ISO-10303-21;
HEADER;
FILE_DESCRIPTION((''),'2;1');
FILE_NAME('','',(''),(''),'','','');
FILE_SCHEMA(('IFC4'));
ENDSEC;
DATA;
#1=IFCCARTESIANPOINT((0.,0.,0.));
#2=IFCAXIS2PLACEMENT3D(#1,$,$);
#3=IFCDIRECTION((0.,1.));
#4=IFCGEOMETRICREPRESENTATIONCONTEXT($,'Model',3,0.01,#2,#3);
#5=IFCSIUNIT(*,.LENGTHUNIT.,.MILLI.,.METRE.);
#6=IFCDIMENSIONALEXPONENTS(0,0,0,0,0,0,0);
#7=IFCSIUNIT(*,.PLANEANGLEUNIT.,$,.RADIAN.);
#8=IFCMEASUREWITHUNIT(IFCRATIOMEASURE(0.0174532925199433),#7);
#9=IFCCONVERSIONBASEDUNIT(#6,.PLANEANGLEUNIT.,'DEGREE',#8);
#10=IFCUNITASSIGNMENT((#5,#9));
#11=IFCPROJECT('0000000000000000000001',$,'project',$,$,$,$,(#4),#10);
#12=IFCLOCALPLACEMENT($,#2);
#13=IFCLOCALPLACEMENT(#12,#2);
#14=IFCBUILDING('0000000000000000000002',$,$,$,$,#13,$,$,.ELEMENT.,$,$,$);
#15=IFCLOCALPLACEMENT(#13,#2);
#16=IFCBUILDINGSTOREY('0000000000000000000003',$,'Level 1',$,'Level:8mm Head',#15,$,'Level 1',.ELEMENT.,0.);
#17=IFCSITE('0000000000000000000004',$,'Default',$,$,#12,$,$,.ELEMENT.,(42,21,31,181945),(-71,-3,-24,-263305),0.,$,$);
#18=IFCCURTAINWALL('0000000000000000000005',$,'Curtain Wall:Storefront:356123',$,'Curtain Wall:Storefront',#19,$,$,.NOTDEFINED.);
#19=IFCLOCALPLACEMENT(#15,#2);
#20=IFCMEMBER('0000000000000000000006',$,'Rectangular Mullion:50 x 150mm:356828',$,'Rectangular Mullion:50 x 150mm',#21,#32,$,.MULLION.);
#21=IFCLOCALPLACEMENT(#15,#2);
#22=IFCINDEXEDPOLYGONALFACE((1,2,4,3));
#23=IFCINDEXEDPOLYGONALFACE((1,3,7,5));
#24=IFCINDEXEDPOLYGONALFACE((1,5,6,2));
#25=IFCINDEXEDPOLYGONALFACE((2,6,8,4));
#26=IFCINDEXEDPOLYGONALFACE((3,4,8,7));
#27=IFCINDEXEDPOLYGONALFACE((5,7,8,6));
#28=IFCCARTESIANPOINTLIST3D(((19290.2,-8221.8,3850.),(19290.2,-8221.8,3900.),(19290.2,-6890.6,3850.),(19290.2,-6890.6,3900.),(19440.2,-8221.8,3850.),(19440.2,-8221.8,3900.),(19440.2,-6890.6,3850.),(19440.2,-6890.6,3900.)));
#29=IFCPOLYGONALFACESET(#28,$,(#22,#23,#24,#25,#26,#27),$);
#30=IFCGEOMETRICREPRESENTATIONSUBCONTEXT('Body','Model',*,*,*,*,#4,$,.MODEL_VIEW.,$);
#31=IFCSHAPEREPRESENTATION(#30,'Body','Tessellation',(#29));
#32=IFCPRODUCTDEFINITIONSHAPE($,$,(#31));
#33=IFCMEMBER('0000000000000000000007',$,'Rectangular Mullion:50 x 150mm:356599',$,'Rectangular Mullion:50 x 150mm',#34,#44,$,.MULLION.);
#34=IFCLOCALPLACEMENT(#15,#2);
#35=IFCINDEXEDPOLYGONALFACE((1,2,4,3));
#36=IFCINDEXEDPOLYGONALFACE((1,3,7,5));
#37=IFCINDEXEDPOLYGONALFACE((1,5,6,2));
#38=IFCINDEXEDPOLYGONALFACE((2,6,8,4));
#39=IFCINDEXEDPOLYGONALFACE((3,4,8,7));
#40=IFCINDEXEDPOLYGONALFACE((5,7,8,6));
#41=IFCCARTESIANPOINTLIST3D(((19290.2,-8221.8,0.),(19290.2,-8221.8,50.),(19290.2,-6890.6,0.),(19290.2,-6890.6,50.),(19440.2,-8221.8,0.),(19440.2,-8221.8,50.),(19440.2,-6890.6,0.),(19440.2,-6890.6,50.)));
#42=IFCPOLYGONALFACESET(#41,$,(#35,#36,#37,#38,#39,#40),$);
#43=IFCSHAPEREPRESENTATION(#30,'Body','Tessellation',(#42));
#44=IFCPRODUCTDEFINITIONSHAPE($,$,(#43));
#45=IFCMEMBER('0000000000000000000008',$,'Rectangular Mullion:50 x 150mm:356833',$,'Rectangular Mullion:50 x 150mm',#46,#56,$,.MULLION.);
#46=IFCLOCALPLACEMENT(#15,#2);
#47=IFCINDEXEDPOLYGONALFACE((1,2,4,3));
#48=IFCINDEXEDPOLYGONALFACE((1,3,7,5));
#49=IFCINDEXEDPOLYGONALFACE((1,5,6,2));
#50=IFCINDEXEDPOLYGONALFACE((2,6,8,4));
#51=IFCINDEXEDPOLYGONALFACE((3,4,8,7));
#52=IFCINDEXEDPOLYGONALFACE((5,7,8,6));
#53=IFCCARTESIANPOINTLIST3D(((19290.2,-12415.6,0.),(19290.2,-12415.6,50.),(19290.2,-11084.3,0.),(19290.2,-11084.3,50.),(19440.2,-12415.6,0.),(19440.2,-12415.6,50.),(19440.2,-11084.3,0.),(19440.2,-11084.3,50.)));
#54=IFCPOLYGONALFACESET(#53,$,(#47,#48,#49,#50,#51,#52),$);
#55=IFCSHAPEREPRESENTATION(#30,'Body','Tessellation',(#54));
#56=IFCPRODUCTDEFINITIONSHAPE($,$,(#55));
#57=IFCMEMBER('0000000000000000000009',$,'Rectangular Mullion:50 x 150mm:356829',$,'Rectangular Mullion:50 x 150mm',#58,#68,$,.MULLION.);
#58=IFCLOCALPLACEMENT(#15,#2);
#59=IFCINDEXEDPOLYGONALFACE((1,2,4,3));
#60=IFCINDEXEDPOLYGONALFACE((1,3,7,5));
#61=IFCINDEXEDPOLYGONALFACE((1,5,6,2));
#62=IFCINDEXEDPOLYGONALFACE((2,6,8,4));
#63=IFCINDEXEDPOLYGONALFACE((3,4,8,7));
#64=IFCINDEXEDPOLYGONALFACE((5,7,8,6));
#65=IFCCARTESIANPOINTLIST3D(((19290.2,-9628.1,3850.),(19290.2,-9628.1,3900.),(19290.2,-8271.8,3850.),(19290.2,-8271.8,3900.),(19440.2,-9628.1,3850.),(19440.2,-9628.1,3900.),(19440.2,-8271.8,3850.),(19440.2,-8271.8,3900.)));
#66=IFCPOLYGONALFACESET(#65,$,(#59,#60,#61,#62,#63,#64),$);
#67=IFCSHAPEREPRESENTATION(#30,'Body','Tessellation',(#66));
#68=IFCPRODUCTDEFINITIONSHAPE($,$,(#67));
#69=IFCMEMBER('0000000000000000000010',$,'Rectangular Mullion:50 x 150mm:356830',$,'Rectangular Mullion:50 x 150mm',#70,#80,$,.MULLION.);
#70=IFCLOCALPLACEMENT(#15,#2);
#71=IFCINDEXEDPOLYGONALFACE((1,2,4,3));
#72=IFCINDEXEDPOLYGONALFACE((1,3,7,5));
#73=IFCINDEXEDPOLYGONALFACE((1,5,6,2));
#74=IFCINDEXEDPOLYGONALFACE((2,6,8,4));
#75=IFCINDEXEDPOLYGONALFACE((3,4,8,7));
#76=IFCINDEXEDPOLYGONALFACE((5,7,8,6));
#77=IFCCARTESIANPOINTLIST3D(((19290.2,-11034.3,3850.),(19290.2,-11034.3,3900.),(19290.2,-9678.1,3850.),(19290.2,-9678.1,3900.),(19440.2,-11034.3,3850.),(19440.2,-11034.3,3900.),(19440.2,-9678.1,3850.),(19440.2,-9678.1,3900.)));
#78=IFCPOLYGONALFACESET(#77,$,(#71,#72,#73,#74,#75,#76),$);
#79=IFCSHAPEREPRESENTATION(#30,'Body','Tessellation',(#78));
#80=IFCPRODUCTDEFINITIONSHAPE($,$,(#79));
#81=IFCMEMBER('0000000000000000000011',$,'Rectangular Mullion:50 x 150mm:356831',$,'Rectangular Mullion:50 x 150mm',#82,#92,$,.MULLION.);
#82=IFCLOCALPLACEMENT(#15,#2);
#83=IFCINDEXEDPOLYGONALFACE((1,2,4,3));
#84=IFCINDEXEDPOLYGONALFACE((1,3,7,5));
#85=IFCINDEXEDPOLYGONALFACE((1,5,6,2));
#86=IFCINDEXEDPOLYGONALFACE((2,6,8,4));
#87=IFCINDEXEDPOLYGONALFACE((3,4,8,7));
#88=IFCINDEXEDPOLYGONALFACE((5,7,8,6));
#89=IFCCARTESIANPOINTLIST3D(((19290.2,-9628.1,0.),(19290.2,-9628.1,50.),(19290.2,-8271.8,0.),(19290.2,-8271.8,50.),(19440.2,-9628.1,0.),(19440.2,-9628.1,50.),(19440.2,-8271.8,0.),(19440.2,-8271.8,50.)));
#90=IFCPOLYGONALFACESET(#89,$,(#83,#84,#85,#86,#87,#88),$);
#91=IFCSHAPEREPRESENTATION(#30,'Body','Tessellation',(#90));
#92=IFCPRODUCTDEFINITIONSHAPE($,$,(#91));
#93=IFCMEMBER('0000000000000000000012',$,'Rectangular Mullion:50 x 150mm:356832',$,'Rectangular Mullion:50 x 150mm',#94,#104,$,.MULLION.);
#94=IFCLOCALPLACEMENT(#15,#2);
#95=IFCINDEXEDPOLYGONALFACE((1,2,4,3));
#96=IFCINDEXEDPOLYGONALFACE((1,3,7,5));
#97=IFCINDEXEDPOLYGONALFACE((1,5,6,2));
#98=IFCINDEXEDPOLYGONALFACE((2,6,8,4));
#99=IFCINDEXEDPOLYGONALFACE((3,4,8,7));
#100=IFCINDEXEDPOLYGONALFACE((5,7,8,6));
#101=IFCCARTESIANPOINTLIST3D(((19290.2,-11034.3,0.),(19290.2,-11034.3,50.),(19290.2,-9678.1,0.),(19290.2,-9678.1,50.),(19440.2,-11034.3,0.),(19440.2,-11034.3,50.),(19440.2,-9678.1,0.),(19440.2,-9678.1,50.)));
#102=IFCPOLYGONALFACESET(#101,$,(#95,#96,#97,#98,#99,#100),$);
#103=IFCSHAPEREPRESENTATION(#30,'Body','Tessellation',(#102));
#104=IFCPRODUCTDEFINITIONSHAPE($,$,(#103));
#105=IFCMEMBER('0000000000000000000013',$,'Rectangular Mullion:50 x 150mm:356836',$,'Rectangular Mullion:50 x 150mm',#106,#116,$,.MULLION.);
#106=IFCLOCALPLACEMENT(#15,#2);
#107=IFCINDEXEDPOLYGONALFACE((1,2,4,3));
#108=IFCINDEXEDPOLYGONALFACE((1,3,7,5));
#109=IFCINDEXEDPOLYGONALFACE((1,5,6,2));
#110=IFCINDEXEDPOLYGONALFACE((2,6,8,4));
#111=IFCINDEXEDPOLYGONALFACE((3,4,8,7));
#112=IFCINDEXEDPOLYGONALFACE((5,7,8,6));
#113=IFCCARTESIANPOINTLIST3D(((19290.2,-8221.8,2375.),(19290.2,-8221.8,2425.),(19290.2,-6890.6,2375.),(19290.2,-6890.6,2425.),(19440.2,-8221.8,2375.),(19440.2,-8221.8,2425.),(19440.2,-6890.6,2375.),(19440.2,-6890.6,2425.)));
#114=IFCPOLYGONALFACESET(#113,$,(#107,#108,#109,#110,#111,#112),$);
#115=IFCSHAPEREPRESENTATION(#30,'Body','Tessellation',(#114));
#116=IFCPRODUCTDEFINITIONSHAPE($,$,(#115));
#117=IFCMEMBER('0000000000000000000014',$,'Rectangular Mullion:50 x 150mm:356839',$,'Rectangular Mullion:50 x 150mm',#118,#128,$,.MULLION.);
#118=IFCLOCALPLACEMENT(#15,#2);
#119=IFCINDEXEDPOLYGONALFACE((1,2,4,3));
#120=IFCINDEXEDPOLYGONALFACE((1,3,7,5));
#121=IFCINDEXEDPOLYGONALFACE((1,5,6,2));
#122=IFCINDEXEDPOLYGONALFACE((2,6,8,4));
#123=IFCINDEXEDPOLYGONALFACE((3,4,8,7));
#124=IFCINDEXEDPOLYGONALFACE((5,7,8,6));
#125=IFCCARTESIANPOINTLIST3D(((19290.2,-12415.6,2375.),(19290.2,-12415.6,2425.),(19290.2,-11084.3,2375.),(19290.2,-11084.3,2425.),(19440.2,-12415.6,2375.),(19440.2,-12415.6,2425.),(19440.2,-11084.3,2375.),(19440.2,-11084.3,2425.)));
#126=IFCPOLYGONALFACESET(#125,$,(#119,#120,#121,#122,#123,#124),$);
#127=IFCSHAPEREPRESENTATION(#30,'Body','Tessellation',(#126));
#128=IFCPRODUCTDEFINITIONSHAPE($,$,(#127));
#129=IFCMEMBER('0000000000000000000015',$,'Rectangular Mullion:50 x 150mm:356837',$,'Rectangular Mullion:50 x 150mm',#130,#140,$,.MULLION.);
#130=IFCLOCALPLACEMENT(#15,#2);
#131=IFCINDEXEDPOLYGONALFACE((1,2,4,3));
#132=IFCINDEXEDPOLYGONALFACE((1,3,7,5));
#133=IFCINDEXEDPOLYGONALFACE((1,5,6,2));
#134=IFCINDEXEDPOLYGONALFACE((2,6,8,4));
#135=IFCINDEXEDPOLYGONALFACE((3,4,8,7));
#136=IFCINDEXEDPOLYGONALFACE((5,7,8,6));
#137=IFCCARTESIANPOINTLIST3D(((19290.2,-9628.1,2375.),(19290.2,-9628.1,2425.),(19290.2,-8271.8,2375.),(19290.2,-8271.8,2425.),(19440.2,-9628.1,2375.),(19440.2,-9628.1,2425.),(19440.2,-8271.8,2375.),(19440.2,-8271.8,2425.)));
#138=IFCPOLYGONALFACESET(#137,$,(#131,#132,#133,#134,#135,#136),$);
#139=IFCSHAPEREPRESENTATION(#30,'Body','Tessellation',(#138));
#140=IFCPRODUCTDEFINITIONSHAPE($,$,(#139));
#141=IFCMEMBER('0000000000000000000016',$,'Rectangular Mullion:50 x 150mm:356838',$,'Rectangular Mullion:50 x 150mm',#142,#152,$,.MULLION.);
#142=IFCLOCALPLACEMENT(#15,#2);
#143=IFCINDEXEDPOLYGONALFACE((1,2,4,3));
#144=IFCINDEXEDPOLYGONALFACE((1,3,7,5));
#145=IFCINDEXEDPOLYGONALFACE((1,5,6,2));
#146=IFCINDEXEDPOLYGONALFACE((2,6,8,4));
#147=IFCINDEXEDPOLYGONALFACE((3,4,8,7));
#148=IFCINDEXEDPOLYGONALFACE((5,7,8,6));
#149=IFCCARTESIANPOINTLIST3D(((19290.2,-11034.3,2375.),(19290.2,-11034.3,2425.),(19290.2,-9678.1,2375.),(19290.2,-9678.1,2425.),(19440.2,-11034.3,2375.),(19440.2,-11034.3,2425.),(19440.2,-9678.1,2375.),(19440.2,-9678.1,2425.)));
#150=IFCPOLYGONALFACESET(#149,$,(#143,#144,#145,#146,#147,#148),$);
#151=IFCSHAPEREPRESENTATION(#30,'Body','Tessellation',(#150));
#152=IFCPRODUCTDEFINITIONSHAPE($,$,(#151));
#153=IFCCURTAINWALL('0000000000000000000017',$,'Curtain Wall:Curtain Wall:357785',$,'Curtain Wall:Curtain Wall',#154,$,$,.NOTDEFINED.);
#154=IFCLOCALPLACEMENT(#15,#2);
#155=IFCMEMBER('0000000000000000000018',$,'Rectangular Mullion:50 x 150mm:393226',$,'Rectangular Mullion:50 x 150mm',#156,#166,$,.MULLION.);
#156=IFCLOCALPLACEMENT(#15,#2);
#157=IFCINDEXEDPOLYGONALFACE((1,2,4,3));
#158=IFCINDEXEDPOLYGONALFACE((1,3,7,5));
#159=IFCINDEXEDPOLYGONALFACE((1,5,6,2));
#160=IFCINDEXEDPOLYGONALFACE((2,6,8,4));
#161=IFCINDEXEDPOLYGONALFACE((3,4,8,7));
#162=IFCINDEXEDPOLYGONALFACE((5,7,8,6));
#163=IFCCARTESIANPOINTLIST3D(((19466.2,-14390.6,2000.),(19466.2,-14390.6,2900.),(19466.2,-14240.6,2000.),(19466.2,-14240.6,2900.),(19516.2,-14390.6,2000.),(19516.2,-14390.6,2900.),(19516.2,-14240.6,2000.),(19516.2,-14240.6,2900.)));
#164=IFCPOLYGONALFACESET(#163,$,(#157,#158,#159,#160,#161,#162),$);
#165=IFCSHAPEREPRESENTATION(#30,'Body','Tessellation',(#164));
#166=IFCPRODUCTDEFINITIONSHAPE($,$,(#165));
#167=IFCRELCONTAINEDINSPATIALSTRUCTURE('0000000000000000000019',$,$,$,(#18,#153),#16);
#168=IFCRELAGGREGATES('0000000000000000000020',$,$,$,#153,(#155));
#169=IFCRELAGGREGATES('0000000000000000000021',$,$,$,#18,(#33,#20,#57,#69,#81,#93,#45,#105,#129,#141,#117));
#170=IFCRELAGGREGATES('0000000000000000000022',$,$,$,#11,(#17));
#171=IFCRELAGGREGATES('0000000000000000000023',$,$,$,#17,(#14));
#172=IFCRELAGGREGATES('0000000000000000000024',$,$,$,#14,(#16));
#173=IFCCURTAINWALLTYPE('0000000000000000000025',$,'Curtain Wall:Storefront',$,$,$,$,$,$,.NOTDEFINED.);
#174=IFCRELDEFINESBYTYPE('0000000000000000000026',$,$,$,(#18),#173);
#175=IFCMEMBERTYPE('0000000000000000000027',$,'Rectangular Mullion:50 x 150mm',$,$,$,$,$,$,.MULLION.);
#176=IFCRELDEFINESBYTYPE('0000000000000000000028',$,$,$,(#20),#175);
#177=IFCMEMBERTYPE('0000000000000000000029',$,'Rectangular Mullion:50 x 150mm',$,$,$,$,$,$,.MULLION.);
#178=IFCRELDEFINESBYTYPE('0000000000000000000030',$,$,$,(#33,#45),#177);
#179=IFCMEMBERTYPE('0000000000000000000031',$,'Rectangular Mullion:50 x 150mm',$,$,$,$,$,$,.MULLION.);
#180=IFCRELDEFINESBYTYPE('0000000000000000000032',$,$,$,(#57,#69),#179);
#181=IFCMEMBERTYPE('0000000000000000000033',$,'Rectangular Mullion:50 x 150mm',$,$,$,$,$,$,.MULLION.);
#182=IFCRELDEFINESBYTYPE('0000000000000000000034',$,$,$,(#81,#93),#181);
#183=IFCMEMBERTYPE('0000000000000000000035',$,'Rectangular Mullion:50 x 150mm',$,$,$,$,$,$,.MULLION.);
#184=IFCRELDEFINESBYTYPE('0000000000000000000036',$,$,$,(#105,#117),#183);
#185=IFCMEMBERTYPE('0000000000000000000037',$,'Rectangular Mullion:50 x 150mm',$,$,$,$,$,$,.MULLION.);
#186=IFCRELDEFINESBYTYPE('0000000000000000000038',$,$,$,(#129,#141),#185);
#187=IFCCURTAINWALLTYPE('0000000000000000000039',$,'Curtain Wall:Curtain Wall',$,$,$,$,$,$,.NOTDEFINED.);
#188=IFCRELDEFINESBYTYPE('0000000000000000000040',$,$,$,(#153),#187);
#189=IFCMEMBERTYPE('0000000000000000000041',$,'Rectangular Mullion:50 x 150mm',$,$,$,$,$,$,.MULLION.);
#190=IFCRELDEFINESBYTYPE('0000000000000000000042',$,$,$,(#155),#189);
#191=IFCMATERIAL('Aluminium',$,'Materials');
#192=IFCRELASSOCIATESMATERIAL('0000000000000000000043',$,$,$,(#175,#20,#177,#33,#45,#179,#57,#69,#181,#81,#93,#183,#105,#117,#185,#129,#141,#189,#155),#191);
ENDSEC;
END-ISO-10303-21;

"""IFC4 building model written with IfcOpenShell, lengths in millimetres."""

from ifc_helpers import new_model, entity, si_unit, converted_unit, direction, frame, origin, place, context, subcontext, project, spatial, indexed_curve, outline, extrude, source, transform, mapped, material, type_object, type_shapes, element, aggregate, save


model = new_model("IFC4")

# Units and contexts
model_context = context("Model", 3, precision=0.01, world=origin(), true_north=direction((0.0, 1.0)))
body_context = subcontext(model_context, "Body", "Model", "MODEL_VIEW")
ifc_project = project(units=[si_unit("LENGTHUNIT", "METRE", prefix="MILLI"), converted_unit("PLANEANGLEUNIT", "DEGREE", entity("IfcRatioMeasure", 0.0174532925199433), si_unit("PLANEANGLEUNIT", "RADIAN"), dimensions=[0, 0, 0, 0, 0, 0, 0])], contexts=[model_context])

# Site, building, storey
site_placement = place(None, origin())
site = spatial("IfcSite", under=ifc_project, at=site_placement, Name="Default", CompositionType="ELEMENT", RefLatitude=(42, 21, 31, 181945), RefLongitude=(-71, -3, -24, -263305), RefElevation=0.0)
building_placement = place(site_placement, origin())
building = spatial("IfcBuilding", under=site, at=building_placement, CompositionType="ELEMENT")
storey_placement = place(building_placement, origin())
storey = spatial("IfcBuildingStorey", under=building, at=storey_placement, Name="Level 1", ObjectType="Level:8mm Head", LongName="Level 1", CompositionType="ELEMENT", Elevation=0.0)

# Shared definitions
curtain_wall_type_1 = type_object("IfcCurtainWallType", Name="Curtain Wall:Storefront", PredefinedType="NOTDEFINED")
ifc_material_1 = material(Name="Aluminium", Category="Materials")

# Curtain walls, members
curtain_wall_1_placement = place(storey_placement, origin())
curtain_wall_1 = element("IfcCurtainWall", 1, at=curtain_wall_1_placement, inside=storey, type_object=curtain_wall_type_1, Name="Curtain Wall:Storefront:356123", ObjectType="Curtain Wall:Storefront", PredefinedType="NOTDEFINED")
member_type_1 = type_object("IfcMemberType", Name="Rectangular Mullion:50 x 150mm", PredefinedType="MULLION", material=ifc_material_1)
shared_shape_1 = source(origin(), body_context, "Body", "SweptSolid", [
    extrude(outline(indexed_curve([(-75.0, -25.0), (75.0, -25.0), (75.0, 25.0), (-75.0, 25.0), (-75.0, -25.0)], self_intersect=False)), frame((-25.0, 0.0, -1331.3), z_axis=(0.0, 0.0, 1.0), x_axis=(0.0, -1.0, 0.0)), (0.0, 0.0, 1.0), 1331.3),
])
type_shapes(member_type_1, [shared_shape_1])
member_1_placement = place(storey_placement, frame((19365.2, -8221.8, 3900.0), z_axis=(0.0, -1.0, 0.0), x_axis=(0.0, 0.0, 1.0)))
member_1 = element("IfcMember", 2, at=member_1_placement, type_object=member_type_1, material=ifc_material_1, Name="Rectangular Mullion:50 x 150mm:356828", ObjectType="Rectangular Mullion:50 x 150mm", PredefinedType="MULLION", context=body_context, shape_type="MappedRepresentation", body=[
    mapped(shared_shape_1, transform((0.0, 0.0, 0.0), scale=1.0)),
])
member_type_2 = type_object("IfcMemberType", Name="Rectangular Mullion:50 x 150mm", PredefinedType="MULLION", material=ifc_material_1)
shared_shape_2 = source(origin(), body_context, "Body", "SweptSolid", [
    extrude(outline(indexed_curve([(-75.0, -25.0), (75.0, -25.0), (75.0, 25.0), (-75.0, 25.0), (-75.0, -25.0)], self_intersect=False)), frame((-25.0, 0.0, -1331.3), z_axis=(0.0, 0.0, 1.0), x_axis=(0.0, -1.0, 0.0)), (0.0, 0.0, 1.0), 1331.3),
])
type_shapes(member_type_2, [shared_shape_2])
member_2_placement = place(storey_placement, frame((19365.2, -6890.6, 0.0), z_axis=(0.0, 1.0, 0.0), x_axis=(0.0, 0.0, -1.0)))
member_2 = element("IfcMember", 3, at=member_2_placement, type_object=member_type_2, material=ifc_material_1, Name="Rectangular Mullion:50 x 150mm:356599", ObjectType="Rectangular Mullion:50 x 150mm", PredefinedType="MULLION", context=body_context, shape_type="MappedRepresentation", body=[
    mapped(shared_shape_2, transform((0.0, 0.0, 0.0), scale=1.0)),
])
member_3_placement = place(storey_placement, frame((19365.2, -11084.3, 0.0), z_axis=(0.0, 1.0, 0.0), x_axis=(0.0, 0.0, -1.0)))
member_3 = element("IfcMember", 4, at=member_3_placement, type_object=member_type_2, material=ifc_material_1, Name="Rectangular Mullion:50 x 150mm:356833", ObjectType="Rectangular Mullion:50 x 150mm", PredefinedType="MULLION", context=body_context, shape_type="MappedRepresentation", body=[
    mapped(shared_shape_2, transform((0.0, 0.0, 0.0), scale=1.0)),
])
member_type_3 = type_object("IfcMemberType", Name="Rectangular Mullion:50 x 150mm", PredefinedType="MULLION", material=ifc_material_1)
shared_shape_3 = source(origin(), body_context, "Body", "SweptSolid", [
    extrude(outline(indexed_curve([(-75.0, -25.0), (75.0, -25.0), (75.0, 25.0), (-75.0, 25.0), (-75.0, -25.0)], self_intersect=False)), frame((-25.0, 0.0, -1356.2), z_axis=(0.0, 0.0, 1.0), x_axis=(0.0, -1.0, 0.0)), (0.0, 0.0, 1.0), 1356.2),
])
type_shapes(member_type_3, [shared_shape_3])
member_4_placement = place(storey_placement, frame((19365.2, -9628.1, 3900.0), z_axis=(0.0, -1.0, 0.0), x_axis=(0.0, 0.0, 1.0)))
member_4 = element("IfcMember", 5, at=member_4_placement, type_object=member_type_3, material=ifc_material_1, Name="Rectangular Mullion:50 x 150mm:356829", ObjectType="Rectangular Mullion:50 x 150mm", PredefinedType="MULLION", context=body_context, shape_type="MappedRepresentation", body=[
    mapped(shared_shape_3, transform((0.0, 0.0, 0.0), scale=1.0)),
])
member_5_placement = place(storey_placement, frame((19365.2, -11034.3, 3900.0), z_axis=(0.0, -1.0, 0.0), x_axis=(0.0, 0.0, 1.0)))
member_5 = element("IfcMember", 6, at=member_5_placement, type_object=member_type_3, material=ifc_material_1, Name="Rectangular Mullion:50 x 150mm:356830", ObjectType="Rectangular Mullion:50 x 150mm", PredefinedType="MULLION", context=body_context, shape_type="MappedRepresentation", body=[
    mapped(shared_shape_3, transform((0.0, 0.0, 0.0), scale=1.0)),
])
member_type_4 = type_object("IfcMemberType", Name="Rectangular Mullion:50 x 150mm", PredefinedType="MULLION", material=ifc_material_1)
shared_shape_4 = source(origin(), body_context, "Body", "SweptSolid", [
    extrude(outline(indexed_curve([(-75.0, -25.0), (75.0, -25.0), (75.0, 25.0), (-75.0, 25.0), (-75.0, -25.0)], self_intersect=False)), frame((-25.0, 0.0, -1356.2), z_axis=(0.0, 0.0, 1.0), x_axis=(0.0, -1.0, 0.0)), (0.0, 0.0, 1.0), 1356.2),
])
type_shapes(member_type_4, [shared_shape_4])
member_6_placement = place(storey_placement, frame((19365.2, -8271.8, 0.0), z_axis=(0.0, 1.0, 0.0), x_axis=(0.0, 0.0, -1.0)))
member_6 = element("IfcMember", 7, at=member_6_placement, type_object=member_type_4, material=ifc_material_1, Name="Rectangular Mullion:50 x 150mm:356831", ObjectType="Rectangular Mullion:50 x 150mm", PredefinedType="MULLION", context=body_context, shape_type="MappedRepresentation", body=[
    mapped(shared_shape_4, transform((0.0, 0.0, 0.0), scale=1.0)),
])
member_7_placement = place(storey_placement, frame((19365.2, -9678.1, 0.0), z_axis=(0.0, 1.0, 0.0), x_axis=(0.0, 0.0, -1.0)))
member_7 = element("IfcMember", 8, at=member_7_placement, type_object=member_type_4, material=ifc_material_1, Name="Rectangular Mullion:50 x 150mm:356832", ObjectType="Rectangular Mullion:50 x 150mm", PredefinedType="MULLION", context=body_context, shape_type="MappedRepresentation", body=[
    mapped(shared_shape_4, transform((0.0, 0.0, 0.0), scale=1.0)),
])
member_type_5 = type_object("IfcMemberType", Name="Rectangular Mullion:50 x 150mm", PredefinedType="MULLION", material=ifc_material_1)
shared_shape_5 = source(origin(), body_context, "Body", "SweptSolid", [
    extrude(outline(indexed_curve([(-75.0, -25.0), (75.0, -25.0), (75.0, 25.0), (-75.0, 25.0), (-75.0, -25.0)], self_intersect=False)), frame((0.0, 0.0, -1331.3), z_axis=(0.0, 0.0, 1.0), x_axis=(0.0, -1.0, 0.0)), (0.0, 0.0, 1.0), 1331.3),
])
type_shapes(member_type_5, [shared_shape_5])
member_8_placement = place(storey_placement, frame((19365.2, -8221.8, 2400.0), z_axis=(0.0, -1.0, 0.0), x_axis=(0.0, 0.0, 1.0)))
member_8 = element("IfcMember", 9, at=member_8_placement, type_object=member_type_5, material=ifc_material_1, Name="Rectangular Mullion:50 x 150mm:356836", ObjectType="Rectangular Mullion:50 x 150mm", PredefinedType="MULLION", context=body_context, shape_type="MappedRepresentation", body=[
    mapped(shared_shape_5, transform((0.0, 0.0, 0.0), scale=1.0)),
])
member_9_placement = place(storey_placement, frame((19365.2, -12415.6, 2400.0), z_axis=(0.0, -1.0, 0.0), x_axis=(0.0, 0.0, 1.0)))
member_9 = element("IfcMember", 10, at=member_9_placement, type_object=member_type_5, material=ifc_material_1, Name="Rectangular Mullion:50 x 150mm:356839", ObjectType="Rectangular Mullion:50 x 150mm", PredefinedType="MULLION", context=body_context, shape_type="MappedRepresentation", body=[
    mapped(shared_shape_5, transform((0.0, 0.0, 0.0), scale=1.0)),
])
member_type_6 = type_object("IfcMemberType", Name="Rectangular Mullion:50 x 150mm", PredefinedType="MULLION", material=ifc_material_1)
shared_shape_6 = source(origin(), body_context, "Body", "SweptSolid", [
    extrude(outline(indexed_curve([(-75.0, -25.0), (75.0, -25.0), (75.0, 25.0), (-75.0, 25.0), (-75.0, -25.0)], self_intersect=False)), frame((0.0, 0.0, -1356.2), z_axis=(0.0, 0.0, 1.0), x_axis=(0.0, -1.0, 0.0)), (0.0, 0.0, 1.0), 1356.2),
])
type_shapes(member_type_6, [shared_shape_6])
member_10_placement = place(storey_placement, frame((19365.2, -9628.1, 2400.0), z_axis=(0.0, -1.0, 0.0), x_axis=(0.0, 0.0, 1.0)))
member_10 = element("IfcMember", 11, at=member_10_placement, type_object=member_type_6, material=ifc_material_1, Name="Rectangular Mullion:50 x 150mm:356837", ObjectType="Rectangular Mullion:50 x 150mm", PredefinedType="MULLION", context=body_context, shape_type="MappedRepresentation", body=[
    mapped(shared_shape_6, transform((0.0, 0.0, 0.0), scale=1.0)),
])
member_11_placement = place(storey_placement, frame((19365.2, -11034.3, 2400.0), z_axis=(0.0, -1.0, 0.0), x_axis=(0.0, 0.0, 1.0)))
member_11 = element("IfcMember", 12, at=member_11_placement, type_object=member_type_6, material=ifc_material_1, Name="Rectangular Mullion:50 x 150mm:356838", ObjectType="Rectangular Mullion:50 x 150mm", PredefinedType="MULLION", context=body_context, shape_type="MappedRepresentation", body=[
    mapped(shared_shape_6, transform((0.0, 0.0, 0.0), scale=1.0)),
])
curtain_wall_type_2 = type_object("IfcCurtainWallType", Name="Curtain Wall:Curtain Wall", PredefinedType="NOTDEFINED")
curtain_wall_2_placement = place(storey_placement, origin())
curtain_wall_2 = element("IfcCurtainWall", 13, at=curtain_wall_2_placement, inside=storey, type_object=curtain_wall_type_2, Name="Curtain Wall:Curtain Wall:357785", ObjectType="Curtain Wall:Curtain Wall", PredefinedType="NOTDEFINED")
member_type_7 = type_object("IfcMemberType", Name="Rectangular Mullion:50 x 150mm", PredefinedType="MULLION", material=ifc_material_1)
shared_shape_7 = source(origin(), body_context, "Body", "SweptSolid", [
    extrude(outline(indexed_curve([(-75.0, -25.0), (75.0, -25.0), (75.0, 25.0), (-75.0, 25.0), (-75.0, -25.0)], self_intersect=False)), frame((-25.0, 0.0, -900.0), z_axis=(0.0, 0.0, 1.0), x_axis=(0.0, -1.0, 0.0)), (0.0, 0.0, 1.0), 900.0),
])
type_shapes(member_type_7, [shared_shape_7])
member_12_placement = place(storey_placement, frame((19466.2, -14315.6, 2900.0), z_axis=(0.0, 0.0, 1.0), x_axis=(-1.0, 0.0, 0.0)))
member_12 = element("IfcMember", 14, at=member_12_placement, type_object=member_type_7, material=ifc_material_1, Name="Rectangular Mullion:50 x 150mm:393226", ObjectType="Rectangular Mullion:50 x 150mm", PredefinedType="MULLION", context=body_context, shape_type="MappedRepresentation", body=[
    mapped(shared_shape_7, transform((0.0, 0.0, 0.0), scale=1.0)),
])
aggregate(curtain_wall_2, [member_12])

aggregate(curtain_wall_1, [member_2, member_1, member_4, member_5, member_6, member_7, member_3, member_8, member_10, member_11, member_9])

save(model, "model.ifc")
